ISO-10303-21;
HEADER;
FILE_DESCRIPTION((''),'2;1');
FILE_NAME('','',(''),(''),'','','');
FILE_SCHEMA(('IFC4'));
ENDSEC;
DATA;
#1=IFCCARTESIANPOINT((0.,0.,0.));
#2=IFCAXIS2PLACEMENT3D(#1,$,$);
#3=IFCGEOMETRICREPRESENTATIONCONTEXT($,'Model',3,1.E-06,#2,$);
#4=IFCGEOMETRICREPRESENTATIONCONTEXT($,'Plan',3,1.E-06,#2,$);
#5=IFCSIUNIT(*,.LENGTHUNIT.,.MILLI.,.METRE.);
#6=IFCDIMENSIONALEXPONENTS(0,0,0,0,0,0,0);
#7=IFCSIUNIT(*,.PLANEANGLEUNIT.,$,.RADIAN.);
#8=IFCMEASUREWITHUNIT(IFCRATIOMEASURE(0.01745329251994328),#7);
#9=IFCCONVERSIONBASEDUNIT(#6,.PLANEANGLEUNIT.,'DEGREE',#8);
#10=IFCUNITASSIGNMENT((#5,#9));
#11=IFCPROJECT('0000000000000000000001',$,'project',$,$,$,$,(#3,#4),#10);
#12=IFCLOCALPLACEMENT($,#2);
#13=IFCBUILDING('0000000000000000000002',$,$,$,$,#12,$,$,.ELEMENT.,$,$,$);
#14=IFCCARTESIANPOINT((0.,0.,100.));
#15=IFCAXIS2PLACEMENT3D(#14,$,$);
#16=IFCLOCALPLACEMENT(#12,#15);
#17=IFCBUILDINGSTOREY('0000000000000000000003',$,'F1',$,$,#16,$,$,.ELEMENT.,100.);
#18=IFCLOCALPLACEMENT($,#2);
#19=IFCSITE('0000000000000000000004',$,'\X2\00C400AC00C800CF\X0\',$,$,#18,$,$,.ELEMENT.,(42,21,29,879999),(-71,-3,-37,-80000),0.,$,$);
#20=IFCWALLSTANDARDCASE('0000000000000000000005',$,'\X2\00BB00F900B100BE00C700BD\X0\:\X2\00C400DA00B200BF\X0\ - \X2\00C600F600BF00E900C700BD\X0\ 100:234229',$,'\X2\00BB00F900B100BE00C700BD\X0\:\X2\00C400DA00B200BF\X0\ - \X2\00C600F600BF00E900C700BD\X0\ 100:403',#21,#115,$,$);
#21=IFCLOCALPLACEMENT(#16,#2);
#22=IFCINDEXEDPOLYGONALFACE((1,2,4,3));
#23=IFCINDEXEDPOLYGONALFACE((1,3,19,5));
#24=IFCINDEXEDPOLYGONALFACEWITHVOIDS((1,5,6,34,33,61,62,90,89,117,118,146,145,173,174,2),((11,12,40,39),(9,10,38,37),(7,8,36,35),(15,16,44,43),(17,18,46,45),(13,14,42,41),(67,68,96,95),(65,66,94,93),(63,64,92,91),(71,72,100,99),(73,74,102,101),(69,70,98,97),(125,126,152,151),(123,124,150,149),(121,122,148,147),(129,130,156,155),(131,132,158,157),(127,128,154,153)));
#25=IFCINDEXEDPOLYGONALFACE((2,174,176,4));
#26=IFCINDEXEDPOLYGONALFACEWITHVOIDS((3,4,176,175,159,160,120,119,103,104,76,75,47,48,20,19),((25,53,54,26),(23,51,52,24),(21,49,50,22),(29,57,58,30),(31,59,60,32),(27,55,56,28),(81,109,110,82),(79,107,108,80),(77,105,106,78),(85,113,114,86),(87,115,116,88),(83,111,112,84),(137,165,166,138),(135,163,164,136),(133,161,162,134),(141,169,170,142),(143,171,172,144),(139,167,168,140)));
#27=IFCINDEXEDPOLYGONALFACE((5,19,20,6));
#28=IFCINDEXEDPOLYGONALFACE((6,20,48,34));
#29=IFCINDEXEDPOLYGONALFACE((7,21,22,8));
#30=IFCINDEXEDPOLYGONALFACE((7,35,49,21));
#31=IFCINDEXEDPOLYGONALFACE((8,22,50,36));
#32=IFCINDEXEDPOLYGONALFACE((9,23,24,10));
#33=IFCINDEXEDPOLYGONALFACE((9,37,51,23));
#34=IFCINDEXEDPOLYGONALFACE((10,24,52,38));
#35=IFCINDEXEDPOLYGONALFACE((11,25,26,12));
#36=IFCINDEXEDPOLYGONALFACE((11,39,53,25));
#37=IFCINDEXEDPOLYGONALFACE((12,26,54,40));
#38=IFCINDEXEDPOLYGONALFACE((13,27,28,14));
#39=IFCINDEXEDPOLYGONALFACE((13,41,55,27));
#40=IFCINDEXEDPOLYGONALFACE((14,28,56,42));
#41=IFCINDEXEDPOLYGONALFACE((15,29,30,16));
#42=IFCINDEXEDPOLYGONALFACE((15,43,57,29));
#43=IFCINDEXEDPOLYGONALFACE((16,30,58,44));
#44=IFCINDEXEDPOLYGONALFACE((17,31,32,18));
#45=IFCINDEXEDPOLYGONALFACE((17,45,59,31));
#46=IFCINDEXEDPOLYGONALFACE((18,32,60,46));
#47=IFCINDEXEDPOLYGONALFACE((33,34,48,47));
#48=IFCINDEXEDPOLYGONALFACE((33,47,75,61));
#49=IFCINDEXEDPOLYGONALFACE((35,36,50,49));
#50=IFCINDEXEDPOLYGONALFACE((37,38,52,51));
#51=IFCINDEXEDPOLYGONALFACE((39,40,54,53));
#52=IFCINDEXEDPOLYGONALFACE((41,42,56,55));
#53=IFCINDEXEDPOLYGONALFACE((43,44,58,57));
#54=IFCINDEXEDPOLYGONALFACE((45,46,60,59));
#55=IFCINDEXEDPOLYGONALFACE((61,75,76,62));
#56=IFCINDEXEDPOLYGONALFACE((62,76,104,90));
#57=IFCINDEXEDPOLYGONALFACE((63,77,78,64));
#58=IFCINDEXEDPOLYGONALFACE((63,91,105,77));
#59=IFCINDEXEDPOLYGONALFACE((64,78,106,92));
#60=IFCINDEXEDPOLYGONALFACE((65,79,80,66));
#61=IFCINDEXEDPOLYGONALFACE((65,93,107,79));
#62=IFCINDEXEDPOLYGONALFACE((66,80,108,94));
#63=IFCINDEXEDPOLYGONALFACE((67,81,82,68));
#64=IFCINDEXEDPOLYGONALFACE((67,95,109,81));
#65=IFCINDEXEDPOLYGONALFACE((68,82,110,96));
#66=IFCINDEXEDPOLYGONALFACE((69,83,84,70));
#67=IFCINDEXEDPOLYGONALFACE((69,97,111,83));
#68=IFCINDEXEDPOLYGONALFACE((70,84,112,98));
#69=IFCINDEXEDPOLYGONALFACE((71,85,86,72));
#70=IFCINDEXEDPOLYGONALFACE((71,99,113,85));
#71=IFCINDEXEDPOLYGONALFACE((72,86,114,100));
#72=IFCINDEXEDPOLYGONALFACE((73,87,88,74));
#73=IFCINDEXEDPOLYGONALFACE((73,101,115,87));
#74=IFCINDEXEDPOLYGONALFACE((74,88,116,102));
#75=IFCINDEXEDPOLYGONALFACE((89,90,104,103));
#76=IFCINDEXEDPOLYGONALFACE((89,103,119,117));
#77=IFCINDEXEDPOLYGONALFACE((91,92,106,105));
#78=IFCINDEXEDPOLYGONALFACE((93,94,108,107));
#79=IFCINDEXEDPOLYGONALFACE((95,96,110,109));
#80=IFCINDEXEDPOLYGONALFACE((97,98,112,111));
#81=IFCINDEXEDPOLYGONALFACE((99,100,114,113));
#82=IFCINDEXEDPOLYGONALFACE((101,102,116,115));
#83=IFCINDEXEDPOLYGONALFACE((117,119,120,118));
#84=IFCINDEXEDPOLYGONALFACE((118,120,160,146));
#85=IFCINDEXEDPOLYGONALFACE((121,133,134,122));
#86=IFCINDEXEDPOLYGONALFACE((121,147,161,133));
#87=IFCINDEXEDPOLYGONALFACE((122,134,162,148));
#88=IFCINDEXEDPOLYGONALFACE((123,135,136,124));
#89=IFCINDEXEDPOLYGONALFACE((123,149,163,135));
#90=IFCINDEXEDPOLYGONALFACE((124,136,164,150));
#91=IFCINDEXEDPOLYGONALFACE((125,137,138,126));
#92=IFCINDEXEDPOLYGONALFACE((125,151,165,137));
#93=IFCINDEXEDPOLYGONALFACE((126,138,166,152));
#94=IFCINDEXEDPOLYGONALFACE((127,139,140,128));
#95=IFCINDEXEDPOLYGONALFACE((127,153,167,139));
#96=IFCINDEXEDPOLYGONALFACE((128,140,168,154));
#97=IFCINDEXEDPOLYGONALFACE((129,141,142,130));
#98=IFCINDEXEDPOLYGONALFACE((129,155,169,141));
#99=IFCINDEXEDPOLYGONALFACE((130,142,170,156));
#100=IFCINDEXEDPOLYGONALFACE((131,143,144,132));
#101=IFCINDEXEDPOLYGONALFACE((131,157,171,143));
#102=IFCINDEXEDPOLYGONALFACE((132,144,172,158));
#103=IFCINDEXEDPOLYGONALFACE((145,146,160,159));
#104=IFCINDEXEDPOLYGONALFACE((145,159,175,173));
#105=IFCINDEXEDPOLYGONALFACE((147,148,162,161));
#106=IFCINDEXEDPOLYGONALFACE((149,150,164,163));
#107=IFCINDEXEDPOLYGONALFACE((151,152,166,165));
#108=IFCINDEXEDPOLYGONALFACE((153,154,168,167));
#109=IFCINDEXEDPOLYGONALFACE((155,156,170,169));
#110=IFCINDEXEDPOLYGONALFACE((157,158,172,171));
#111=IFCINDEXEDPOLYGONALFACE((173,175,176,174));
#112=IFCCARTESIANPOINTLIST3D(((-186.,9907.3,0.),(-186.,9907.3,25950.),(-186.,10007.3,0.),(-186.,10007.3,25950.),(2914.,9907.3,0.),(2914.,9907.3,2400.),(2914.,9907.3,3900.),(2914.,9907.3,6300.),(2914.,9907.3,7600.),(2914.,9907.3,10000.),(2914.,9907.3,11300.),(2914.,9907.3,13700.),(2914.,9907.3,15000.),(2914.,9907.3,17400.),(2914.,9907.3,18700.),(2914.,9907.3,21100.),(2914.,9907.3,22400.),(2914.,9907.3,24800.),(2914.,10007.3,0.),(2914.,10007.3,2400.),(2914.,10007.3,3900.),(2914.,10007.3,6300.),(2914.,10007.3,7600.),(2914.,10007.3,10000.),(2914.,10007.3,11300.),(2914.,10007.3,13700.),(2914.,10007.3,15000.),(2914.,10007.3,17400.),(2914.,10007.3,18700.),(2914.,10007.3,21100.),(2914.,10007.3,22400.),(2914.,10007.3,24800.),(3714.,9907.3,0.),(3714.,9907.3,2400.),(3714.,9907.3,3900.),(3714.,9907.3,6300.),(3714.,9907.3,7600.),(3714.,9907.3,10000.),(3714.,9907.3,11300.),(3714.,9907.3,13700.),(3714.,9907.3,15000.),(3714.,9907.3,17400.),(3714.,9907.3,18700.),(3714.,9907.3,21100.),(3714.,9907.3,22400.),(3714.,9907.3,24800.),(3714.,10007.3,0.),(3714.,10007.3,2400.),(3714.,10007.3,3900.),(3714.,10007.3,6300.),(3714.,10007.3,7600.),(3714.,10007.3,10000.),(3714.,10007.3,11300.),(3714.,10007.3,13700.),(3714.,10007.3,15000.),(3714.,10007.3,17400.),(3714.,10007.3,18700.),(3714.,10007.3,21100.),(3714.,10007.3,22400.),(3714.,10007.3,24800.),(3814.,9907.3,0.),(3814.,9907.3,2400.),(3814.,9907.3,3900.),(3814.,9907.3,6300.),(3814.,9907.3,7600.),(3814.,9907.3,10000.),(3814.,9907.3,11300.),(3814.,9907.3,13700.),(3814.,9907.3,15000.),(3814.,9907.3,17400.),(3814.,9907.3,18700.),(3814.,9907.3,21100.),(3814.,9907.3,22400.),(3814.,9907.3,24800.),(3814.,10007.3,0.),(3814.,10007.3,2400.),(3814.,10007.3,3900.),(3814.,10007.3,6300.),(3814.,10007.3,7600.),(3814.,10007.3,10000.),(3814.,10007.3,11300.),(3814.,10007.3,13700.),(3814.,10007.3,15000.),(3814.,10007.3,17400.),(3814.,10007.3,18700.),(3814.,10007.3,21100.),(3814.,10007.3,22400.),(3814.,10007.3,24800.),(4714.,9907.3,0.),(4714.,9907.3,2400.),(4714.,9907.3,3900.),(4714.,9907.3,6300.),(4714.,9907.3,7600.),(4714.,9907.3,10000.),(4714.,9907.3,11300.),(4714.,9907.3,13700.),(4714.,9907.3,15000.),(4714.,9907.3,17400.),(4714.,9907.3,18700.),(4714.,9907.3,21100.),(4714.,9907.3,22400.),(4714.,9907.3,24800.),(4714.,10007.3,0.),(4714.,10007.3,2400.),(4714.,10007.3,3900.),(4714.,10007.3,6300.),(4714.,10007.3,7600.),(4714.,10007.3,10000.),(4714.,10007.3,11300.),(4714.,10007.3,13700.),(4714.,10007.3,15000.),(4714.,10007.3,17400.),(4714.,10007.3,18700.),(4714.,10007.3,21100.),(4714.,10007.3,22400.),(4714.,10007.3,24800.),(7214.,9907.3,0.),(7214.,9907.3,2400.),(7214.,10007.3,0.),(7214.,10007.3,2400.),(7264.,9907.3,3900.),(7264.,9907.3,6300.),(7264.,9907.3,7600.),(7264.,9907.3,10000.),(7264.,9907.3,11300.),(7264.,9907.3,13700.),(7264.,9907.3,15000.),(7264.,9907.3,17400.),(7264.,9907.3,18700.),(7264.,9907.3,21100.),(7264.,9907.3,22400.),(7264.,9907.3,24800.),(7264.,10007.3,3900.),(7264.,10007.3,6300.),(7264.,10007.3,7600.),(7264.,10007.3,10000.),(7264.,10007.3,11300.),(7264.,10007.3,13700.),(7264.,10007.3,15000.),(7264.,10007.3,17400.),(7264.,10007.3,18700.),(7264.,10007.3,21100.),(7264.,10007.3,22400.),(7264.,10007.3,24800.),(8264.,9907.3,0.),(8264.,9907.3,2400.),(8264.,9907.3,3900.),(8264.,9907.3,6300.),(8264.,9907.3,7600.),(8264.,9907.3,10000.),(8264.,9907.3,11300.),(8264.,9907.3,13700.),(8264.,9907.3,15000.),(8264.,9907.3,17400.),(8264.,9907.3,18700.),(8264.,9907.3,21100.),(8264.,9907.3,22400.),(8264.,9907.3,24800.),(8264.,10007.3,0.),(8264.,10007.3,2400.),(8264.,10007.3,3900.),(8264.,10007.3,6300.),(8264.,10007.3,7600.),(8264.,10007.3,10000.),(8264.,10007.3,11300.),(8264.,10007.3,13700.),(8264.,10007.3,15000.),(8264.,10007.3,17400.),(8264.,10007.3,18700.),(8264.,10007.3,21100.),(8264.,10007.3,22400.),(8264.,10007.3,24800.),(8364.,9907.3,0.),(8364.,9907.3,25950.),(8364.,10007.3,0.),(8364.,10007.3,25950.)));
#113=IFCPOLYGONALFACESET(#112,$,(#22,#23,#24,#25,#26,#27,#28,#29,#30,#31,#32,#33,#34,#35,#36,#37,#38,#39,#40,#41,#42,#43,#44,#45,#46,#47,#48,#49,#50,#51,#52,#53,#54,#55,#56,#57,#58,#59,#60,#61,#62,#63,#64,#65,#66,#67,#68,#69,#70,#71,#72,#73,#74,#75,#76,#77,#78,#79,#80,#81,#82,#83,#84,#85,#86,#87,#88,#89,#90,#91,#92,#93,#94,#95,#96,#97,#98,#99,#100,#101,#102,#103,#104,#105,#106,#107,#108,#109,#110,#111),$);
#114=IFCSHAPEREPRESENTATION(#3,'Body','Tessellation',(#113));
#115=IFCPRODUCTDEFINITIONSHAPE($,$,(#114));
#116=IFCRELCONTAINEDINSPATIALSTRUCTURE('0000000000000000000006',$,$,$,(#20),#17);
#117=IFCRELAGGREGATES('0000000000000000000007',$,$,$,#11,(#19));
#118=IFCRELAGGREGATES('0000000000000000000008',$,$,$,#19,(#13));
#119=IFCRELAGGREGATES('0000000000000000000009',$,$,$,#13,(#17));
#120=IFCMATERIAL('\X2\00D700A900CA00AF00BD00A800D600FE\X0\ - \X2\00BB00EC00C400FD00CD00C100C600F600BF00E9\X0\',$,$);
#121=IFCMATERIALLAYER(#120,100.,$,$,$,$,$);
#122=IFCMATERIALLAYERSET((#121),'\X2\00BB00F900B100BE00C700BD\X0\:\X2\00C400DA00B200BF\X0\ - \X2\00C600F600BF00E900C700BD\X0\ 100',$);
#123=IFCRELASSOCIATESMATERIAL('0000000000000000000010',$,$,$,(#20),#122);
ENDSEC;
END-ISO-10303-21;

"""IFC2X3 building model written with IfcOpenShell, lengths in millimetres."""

from ifc_helpers import new_model, entity, si_unit, converted_unit, frame, frame_2d, origin, origin_2d_with_axis, place, context, project, spatial, polyline, rectangle, extrude, clip, bounded_halfspace, material, layer, layer_set, layer_usage, element, save


model = new_model("IFC2X3")

# Units and contexts
model_context = context("Model", 3, precision=1e-06, world=origin())
plan_context = context("Plan", 3, precision=1e-06, world=origin())
ifc_project = project(units=[si_unit("LENGTHUNIT", "METRE", prefix="MILLI"), converted_unit("PLANEANGLEUNIT", "DEGREE", entity("IfcRatioMeasure", 0.01745329251994328), si_unit("PLANEANGLEUNIT", "RADIAN"), dimensions=[0, 0, 0, 0, 0, 0, 0])], contexts=[model_context, plan_context])

# Site, building, storey
site_placement = place(None, origin())
site = spatial("IfcSite", under=ifc_project, at=site_placement, Name="Ä¬ÈÏ", CompositionType="ELEMENT", RefLatitude=(42, 21, 29, 879999), RefLongitude=(-71, -3, -37, -80000), RefElevation=0.0)
building_placement = place(None, origin())
building = spatial("IfcBuilding", under=site, at=building_placement, CompositionType="ELEMENT")
storey_placement = place(building_placement, frame((0.0, 0.0, 100.0)))
storey = spatial("IfcBuildingStorey", under=building, at=storey_placement, Name="F1", CompositionType="ELEMENT", Elevation=100.0)

# Wall, openings
ifc_material = material(Name="×©Ê¯½¨Öþ - »ìÄýÍÁÆö¿é")
ifc_layer = layer(ifc_material, 100.0)
ifc_layer_set = layer_set([ifc_layer], Name="»ù±¾Ç½:ÄÚ²¿ - Æö¿éÇ½ 100")
ifc_layer_usage = layer_usage(ifc_layer_set, "AXIS2", "NEGATIVE", 50.0)
wall_placement = place(storey_placement, frame((-186.0, 9957.3, 0.0)))
wall = element("IfcWallStandardCase", 1, at=wall_placement, inside=storey, material=ifc_layer_usage, Name="»ù±¾Ç½:ÄÚ²¿ - Æö¿éÇ½ 100:234229", ObjectType="»ù±¾Ç½:ÄÚ²¿ - Æö¿éÇ½ 100:403", context=model_context, shape_type="Clipping", body=[
    clip(extrude(rectangle(XDim=8550.0, YDim=100.0, at=frame_2d((4275.0, 0.0), x_axis=(-1.0, 0.0))), origin(), (0.0, 0.0, 1.0), 25950.0), bounded_halfspace(frame((0.0, -50.0, 25950.0), z_axis=(0.0, 0.0, -1.0), x_axis=(1.0, 0.0, 0.0)), True, frame((0.0, -50.0, 25950.0)), polyline([(0.0, 0.0), (8550.0, 0.0), (8550.0, 100.0), (7450.0, 100.0), (7350.0, 100.0), (5500.0, 100.0), (5400.0, 100.0), (4000.0, 100.0), (3900.0, 100.0), (2100.0, 100.0), (2000.0, 100.0), (0.0, 100.0), (0.0, 0.0)]))),
])
opening_1_placement = place(wall_placement, origin())
element("IfcOpeningElement", 2, at=opening_1_placement, cuts=wall, ObjectType="Opening", context=model_context, shape_type="SweptSolid", body=[
    extrude(rectangle(XDim=2400.0, YDim=800.0, at=origin_2d_with_axis()), frame((3500.0, -50.0, 1200.0), z_axis=(0.0, 1.0, 0.0), x_axis=(0.0, 0.0, -1.0)), (0.0, 0.0, 1.0), 100.0),
])
opening_2_placement = place(wall_placement, origin())
element("IfcOpeningElement", 3, at=opening_2_placement, cuts=wall, ObjectType="Opening", context=model_context, shape_type="SweptSolid", body=[
    extrude(rectangle(XDim=2400.0, YDim=900.0, at=origin_2d_with_axis()), frame((4450.0, -50.0, 1200.0), z_axis=(0.0, 1.0, 0.0), x_axis=(0.0, 0.0, -1.0)), (0.0, 0.0, 1.0), 100.0),
])
opening_3_placement = place(wall_placement, origin())
element("IfcOpeningElement", 4, at=opening_3_placement, cuts=wall, ObjectType="Opening", context=model_context, shape_type="SweptSolid", body=[
    extrude(rectangle(XDim=2400.0, YDim=800.0, at=origin_2d_with_axis()), frame((3500.0, -50.0, 5100.0), z_axis=(0.0, 1.0, 0.0), x_axis=(0.0, 0.0, -1.0)), (0.0, 0.0, 1.0), 100.0),
])
opening_4_placement = place(wall_placement, origin())
element("IfcOpeningElement", 5, at=opening_4_placement, cuts=wall, ObjectType="Opening", context=model_context, shape_type="SweptSolid", body=[
    extrude(rectangle(XDim=2400.0, YDim=800.0, at=origin_2d_with_axis()), frame((3500.0, -50.0, 8800.0), z_axis=(0.0, 1.0, 0.0), x_axis=(0.0, 0.0, -1.0)), (0.0, 0.0, 1.0), 100.0),
])
opening_5_placement = place(wall_placement, origin())
element("IfcOpeningElement", 6, at=opening_5_placement, cuts=wall, ObjectType="Opening", context=model_context, shape_type="SweptSolid", body=[
    extrude(rectangle(XDim=2400.0, YDim=800.0, at=origin_2d_with_axis()), frame((3500.0, -50.0, 12500.0), z_axis=(0.0, 1.0, 0.0), x_axis=(0.0, 0.0, -1.0)), (0.0, 0.0, 1.0), 100.0),
])
opening_6_placement = place(wall_placement, origin())
element("IfcOpeningElement", 7, at=opening_6_placement, cuts=wall, ObjectType="Opening", context=model_context, shape_type="SweptSolid", body=[
    extrude(rectangle(XDim=2400.0, YDim=800.0, at=origin_2d_with_axis()), frame((3500.0, -50.0, 16200.0), z_axis=(0.0, 1.0, 0.0), x_axis=(0.0, 0.0, -1.0)), (0.0, 0.0, 1.0), 100.0),
])
opening_7_placement = place(wall_placement, origin())
element("IfcOpeningElement", 8, at=opening_7_placement, cuts=wall, ObjectType="Opening", context=model_context, shape_type="SweptSolid", body=[
    extrude(rectangle(XDim=2400.0, YDim=800.0, at=origin_2d_with_axis()), frame((3500.0, -50.0, 19900.0), z_axis=(0.0, 1.0, 0.0), x_axis=(0.0, 0.0, -1.0)), (0.0, 0.0, 1.0), 100.0),
])
opening_8_placement = place(wall_placement, origin())
element("IfcOpeningElement", 9, at=opening_8_placement, cuts=wall, ObjectType="Opening", context=model_context, shape_type="SweptSolid", body=[
    extrude(rectangle(XDim=2400.0, YDim=800.0, at=origin_2d_with_axis()), frame((3500.0, -50.0, 23600.0), z_axis=(0.0, 1.0, 0.0), x_axis=(0.0, 0.0, -1.0)), (0.0, 0.0, 1.0), 100.0),
])
opening_9_placement = place(wall_placement, origin())
element("IfcOpeningElement", 10, at=opening_9_placement, cuts=wall, ObjectType="Opening", context=model_context, shape_type="SweptSolid", body=[
    extrude(rectangle(XDim=2400.0, YDim=900.0, at=origin_2d_with_axis()), frame((4450.0, -50.0, 5100.0), z_axis=(0.0, 1.0, 0.0), x_axis=(0.0, 0.0, -1.0)), (0.0, 0.0, 1.0), 100.0),
])
opening_10_placement = place(wall_placement, origin())
element("IfcOpeningElement", 11, at=opening_10_placement, cuts=wall, ObjectType="Opening", context=model_context, shape_type="SweptSolid", body=[
    extrude(rectangle(XDim=2400.0, YDim=900.0, at=origin_2d_with_axis()), frame((4450.0, -50.0, 8800.0), z_axis=(0.0, 1.0, 0.0), x_axis=(0.0, 0.0, -1.0)), (0.0, 0.0, 1.0), 100.0),
])
opening_11_placement = place(wall_placement, origin())
element("IfcOpeningElement", 12, at=opening_11_placement, cuts=wall, ObjectType="Opening", context=model_context, shape_type="SweptSolid", body=[
    extrude(rectangle(XDim=2400.0, YDim=900.0, at=origin_2d_with_axis()), frame((4450.0, -50.0, 12500.0), z_axis=(0.0, 1.0, 0.0), x_axis=(0.0, 0.0, -1.0)), (0.0, 0.0, 1.0), 100.0),
])
opening_12_placement = place(wall_placement, origin())
element("IfcOpeningElement", 13, at=opening_12_placement, cuts=wall, ObjectType="Opening", context=model_context, shape_type="SweptSolid", body=[
    extrude(rectangle(XDim=2400.0, YDim=900.0, at=origin_2d_with_axis()), frame((4450.0, -50.0, 16200.0), z_axis=(0.0, 1.0, 0.0), x_axis=(0.0, 0.0, -1.0)), (0.0, 0.0, 1.0), 100.0),
])
opening_13_placement = place(wall_placement, origin())
element("IfcOpeningElement", 14, at=opening_13_placement, cuts=wall, ObjectType="Opening", context=model_context, shape_type="SweptSolid", body=[
    extrude(rectangle(XDim=2400.0, YDim=900.0, at=origin_2d_with_axis()), frame((4450.0, -50.0, 19900.0), z_axis=(0.0, 1.0, 0.0), x_axis=(0.0, 0.0, -1.0)), (0.0, 0.0, 1.0), 100.0),
])
opening_14_placement = place(wall_placement, origin())
element("IfcOpeningElement", 15, at=opening_14_placement, cuts=wall, ObjectType="Opening", context=model_context, shape_type="SweptSolid", body=[
    extrude(rectangle(XDim=2400.0, YDim=900.0, at=origin_2d_with_axis()), frame((4450.0, -50.0, 23600.0), z_axis=(0.0, 1.0, 0.0), x_axis=(0.0, 0.0, -1.0)), (0.0, 0.0, 1.0), 100.0),
])
opening_15_placement = place(wall_placement, origin())
element("IfcOpeningElement", 16, at=opening_15_placement, cuts=wall, ObjectType="Opening", context=model_context, shape_type="SweptSolid", body=[
    extrude(rectangle(XDim=2400.0, YDim=1050.0, at=origin_2d_with_axis()), frame((7925.0, -50.0, 1200.0), z_axis=(0.0, 1.0, 0.0), x_axis=(0.0, 0.0, -1.0)), (0.0, 0.0, 1.0), 100.0),
])
opening_16_placement = place(wall_placement, origin())
element("IfcOpeningElement", 17, at=opening_16_placement, cuts=wall, ObjectType="Opening", context=model_context, shape_type="SweptSolid", body=[
    extrude(rectangle(XDim=2400.0, YDim=1000.0, at=origin_2d_with_axis()), frame((7950.0, -50.0, 5100.0), z_axis=(0.0, 1.0, 0.0), x_axis=(0.0, 0.0, -1.0)), (0.0, 0.0, 1.0), 100.0),
])
opening_17_placement = place(wall_placement, origin())
element("IfcOpeningElement", 18, at=opening_17_placement, cuts=wall, ObjectType="Opening", context=model_context, shape_type="SweptSolid", body=[
    extrude(rectangle(XDim=2400.0, YDim=1000.0, at=origin_2d_with_axis()), frame((7950.0, -50.0, 8800.0), z_axis=(0.0, 1.0, 0.0), x_axis=(0.0, 0.0, -1.0)), (0.0, 0.0, 1.0), 100.0),
])
opening_18_placement = place(wall_placement, origin())
element("IfcOpeningElement", 19, at=opening_18_placement, cuts=wall, ObjectType="Opening", context=model_context, shape_type="SweptSolid", body=[
    extrude(rectangle(XDim=2400.0, YDim=1000.0, at=origin_2d_with_axis()), frame((7950.0, -50.0, 12500.0), z_axis=(0.0, 1.0, 0.0), x_axis=(0.0, 0.0, -1.0)), (0.0, 0.0, 1.0), 100.0),
])
opening_19_placement = place(wall_placement, origin())
element("IfcOpeningElement", 20, at=opening_19_placement, cuts=wall, ObjectType="Opening", context=model_context, shape_type="SweptSolid", body=[
    extrude(rectangle(XDim=2400.0, YDim=1000.0, at=origin_2d_with_axis()), frame((7950.0, -50.0, 16200.0), z_axis=(0.0, 1.0, 0.0), x_axis=(0.0, 0.0, -1.0)), (0.0, 0.0, 1.0), 100.0),
])
opening_20_placement = place(wall_placement, origin())
element("IfcOpeningElement", 21, at=opening_20_placement, cuts=wall, ObjectType="Opening", context=model_context, shape_type="SweptSolid", body=[
    extrude(rectangle(XDim=2400.0, YDim=1000.0, at=origin_2d_with_axis()), frame((7950.0, -50.0, 19900.0), z_axis=(0.0, 1.0, 0.0), x_axis=(0.0, 0.0, -1.0)), (0.0, 0.0, 1.0), 100.0),
])
opening_21_placement = place(wall_placement, origin())
element("IfcOpeningElement", 22, at=opening_21_placement, cuts=wall, ObjectType="Opening", context=model_context, shape_type="SweptSolid", body=[
    extrude(rectangle(XDim=2400.0, YDim=1000.0, at=origin_2d_with_axis()), frame((7950.0, -50.0, 23600.0), z_axis=(0.0, 1.0, 0.0), x_axis=(0.0, 0.0, -1.0)), (0.0, 0.0, 1.0), 100.0),
])

save(model, "model.ifc")
